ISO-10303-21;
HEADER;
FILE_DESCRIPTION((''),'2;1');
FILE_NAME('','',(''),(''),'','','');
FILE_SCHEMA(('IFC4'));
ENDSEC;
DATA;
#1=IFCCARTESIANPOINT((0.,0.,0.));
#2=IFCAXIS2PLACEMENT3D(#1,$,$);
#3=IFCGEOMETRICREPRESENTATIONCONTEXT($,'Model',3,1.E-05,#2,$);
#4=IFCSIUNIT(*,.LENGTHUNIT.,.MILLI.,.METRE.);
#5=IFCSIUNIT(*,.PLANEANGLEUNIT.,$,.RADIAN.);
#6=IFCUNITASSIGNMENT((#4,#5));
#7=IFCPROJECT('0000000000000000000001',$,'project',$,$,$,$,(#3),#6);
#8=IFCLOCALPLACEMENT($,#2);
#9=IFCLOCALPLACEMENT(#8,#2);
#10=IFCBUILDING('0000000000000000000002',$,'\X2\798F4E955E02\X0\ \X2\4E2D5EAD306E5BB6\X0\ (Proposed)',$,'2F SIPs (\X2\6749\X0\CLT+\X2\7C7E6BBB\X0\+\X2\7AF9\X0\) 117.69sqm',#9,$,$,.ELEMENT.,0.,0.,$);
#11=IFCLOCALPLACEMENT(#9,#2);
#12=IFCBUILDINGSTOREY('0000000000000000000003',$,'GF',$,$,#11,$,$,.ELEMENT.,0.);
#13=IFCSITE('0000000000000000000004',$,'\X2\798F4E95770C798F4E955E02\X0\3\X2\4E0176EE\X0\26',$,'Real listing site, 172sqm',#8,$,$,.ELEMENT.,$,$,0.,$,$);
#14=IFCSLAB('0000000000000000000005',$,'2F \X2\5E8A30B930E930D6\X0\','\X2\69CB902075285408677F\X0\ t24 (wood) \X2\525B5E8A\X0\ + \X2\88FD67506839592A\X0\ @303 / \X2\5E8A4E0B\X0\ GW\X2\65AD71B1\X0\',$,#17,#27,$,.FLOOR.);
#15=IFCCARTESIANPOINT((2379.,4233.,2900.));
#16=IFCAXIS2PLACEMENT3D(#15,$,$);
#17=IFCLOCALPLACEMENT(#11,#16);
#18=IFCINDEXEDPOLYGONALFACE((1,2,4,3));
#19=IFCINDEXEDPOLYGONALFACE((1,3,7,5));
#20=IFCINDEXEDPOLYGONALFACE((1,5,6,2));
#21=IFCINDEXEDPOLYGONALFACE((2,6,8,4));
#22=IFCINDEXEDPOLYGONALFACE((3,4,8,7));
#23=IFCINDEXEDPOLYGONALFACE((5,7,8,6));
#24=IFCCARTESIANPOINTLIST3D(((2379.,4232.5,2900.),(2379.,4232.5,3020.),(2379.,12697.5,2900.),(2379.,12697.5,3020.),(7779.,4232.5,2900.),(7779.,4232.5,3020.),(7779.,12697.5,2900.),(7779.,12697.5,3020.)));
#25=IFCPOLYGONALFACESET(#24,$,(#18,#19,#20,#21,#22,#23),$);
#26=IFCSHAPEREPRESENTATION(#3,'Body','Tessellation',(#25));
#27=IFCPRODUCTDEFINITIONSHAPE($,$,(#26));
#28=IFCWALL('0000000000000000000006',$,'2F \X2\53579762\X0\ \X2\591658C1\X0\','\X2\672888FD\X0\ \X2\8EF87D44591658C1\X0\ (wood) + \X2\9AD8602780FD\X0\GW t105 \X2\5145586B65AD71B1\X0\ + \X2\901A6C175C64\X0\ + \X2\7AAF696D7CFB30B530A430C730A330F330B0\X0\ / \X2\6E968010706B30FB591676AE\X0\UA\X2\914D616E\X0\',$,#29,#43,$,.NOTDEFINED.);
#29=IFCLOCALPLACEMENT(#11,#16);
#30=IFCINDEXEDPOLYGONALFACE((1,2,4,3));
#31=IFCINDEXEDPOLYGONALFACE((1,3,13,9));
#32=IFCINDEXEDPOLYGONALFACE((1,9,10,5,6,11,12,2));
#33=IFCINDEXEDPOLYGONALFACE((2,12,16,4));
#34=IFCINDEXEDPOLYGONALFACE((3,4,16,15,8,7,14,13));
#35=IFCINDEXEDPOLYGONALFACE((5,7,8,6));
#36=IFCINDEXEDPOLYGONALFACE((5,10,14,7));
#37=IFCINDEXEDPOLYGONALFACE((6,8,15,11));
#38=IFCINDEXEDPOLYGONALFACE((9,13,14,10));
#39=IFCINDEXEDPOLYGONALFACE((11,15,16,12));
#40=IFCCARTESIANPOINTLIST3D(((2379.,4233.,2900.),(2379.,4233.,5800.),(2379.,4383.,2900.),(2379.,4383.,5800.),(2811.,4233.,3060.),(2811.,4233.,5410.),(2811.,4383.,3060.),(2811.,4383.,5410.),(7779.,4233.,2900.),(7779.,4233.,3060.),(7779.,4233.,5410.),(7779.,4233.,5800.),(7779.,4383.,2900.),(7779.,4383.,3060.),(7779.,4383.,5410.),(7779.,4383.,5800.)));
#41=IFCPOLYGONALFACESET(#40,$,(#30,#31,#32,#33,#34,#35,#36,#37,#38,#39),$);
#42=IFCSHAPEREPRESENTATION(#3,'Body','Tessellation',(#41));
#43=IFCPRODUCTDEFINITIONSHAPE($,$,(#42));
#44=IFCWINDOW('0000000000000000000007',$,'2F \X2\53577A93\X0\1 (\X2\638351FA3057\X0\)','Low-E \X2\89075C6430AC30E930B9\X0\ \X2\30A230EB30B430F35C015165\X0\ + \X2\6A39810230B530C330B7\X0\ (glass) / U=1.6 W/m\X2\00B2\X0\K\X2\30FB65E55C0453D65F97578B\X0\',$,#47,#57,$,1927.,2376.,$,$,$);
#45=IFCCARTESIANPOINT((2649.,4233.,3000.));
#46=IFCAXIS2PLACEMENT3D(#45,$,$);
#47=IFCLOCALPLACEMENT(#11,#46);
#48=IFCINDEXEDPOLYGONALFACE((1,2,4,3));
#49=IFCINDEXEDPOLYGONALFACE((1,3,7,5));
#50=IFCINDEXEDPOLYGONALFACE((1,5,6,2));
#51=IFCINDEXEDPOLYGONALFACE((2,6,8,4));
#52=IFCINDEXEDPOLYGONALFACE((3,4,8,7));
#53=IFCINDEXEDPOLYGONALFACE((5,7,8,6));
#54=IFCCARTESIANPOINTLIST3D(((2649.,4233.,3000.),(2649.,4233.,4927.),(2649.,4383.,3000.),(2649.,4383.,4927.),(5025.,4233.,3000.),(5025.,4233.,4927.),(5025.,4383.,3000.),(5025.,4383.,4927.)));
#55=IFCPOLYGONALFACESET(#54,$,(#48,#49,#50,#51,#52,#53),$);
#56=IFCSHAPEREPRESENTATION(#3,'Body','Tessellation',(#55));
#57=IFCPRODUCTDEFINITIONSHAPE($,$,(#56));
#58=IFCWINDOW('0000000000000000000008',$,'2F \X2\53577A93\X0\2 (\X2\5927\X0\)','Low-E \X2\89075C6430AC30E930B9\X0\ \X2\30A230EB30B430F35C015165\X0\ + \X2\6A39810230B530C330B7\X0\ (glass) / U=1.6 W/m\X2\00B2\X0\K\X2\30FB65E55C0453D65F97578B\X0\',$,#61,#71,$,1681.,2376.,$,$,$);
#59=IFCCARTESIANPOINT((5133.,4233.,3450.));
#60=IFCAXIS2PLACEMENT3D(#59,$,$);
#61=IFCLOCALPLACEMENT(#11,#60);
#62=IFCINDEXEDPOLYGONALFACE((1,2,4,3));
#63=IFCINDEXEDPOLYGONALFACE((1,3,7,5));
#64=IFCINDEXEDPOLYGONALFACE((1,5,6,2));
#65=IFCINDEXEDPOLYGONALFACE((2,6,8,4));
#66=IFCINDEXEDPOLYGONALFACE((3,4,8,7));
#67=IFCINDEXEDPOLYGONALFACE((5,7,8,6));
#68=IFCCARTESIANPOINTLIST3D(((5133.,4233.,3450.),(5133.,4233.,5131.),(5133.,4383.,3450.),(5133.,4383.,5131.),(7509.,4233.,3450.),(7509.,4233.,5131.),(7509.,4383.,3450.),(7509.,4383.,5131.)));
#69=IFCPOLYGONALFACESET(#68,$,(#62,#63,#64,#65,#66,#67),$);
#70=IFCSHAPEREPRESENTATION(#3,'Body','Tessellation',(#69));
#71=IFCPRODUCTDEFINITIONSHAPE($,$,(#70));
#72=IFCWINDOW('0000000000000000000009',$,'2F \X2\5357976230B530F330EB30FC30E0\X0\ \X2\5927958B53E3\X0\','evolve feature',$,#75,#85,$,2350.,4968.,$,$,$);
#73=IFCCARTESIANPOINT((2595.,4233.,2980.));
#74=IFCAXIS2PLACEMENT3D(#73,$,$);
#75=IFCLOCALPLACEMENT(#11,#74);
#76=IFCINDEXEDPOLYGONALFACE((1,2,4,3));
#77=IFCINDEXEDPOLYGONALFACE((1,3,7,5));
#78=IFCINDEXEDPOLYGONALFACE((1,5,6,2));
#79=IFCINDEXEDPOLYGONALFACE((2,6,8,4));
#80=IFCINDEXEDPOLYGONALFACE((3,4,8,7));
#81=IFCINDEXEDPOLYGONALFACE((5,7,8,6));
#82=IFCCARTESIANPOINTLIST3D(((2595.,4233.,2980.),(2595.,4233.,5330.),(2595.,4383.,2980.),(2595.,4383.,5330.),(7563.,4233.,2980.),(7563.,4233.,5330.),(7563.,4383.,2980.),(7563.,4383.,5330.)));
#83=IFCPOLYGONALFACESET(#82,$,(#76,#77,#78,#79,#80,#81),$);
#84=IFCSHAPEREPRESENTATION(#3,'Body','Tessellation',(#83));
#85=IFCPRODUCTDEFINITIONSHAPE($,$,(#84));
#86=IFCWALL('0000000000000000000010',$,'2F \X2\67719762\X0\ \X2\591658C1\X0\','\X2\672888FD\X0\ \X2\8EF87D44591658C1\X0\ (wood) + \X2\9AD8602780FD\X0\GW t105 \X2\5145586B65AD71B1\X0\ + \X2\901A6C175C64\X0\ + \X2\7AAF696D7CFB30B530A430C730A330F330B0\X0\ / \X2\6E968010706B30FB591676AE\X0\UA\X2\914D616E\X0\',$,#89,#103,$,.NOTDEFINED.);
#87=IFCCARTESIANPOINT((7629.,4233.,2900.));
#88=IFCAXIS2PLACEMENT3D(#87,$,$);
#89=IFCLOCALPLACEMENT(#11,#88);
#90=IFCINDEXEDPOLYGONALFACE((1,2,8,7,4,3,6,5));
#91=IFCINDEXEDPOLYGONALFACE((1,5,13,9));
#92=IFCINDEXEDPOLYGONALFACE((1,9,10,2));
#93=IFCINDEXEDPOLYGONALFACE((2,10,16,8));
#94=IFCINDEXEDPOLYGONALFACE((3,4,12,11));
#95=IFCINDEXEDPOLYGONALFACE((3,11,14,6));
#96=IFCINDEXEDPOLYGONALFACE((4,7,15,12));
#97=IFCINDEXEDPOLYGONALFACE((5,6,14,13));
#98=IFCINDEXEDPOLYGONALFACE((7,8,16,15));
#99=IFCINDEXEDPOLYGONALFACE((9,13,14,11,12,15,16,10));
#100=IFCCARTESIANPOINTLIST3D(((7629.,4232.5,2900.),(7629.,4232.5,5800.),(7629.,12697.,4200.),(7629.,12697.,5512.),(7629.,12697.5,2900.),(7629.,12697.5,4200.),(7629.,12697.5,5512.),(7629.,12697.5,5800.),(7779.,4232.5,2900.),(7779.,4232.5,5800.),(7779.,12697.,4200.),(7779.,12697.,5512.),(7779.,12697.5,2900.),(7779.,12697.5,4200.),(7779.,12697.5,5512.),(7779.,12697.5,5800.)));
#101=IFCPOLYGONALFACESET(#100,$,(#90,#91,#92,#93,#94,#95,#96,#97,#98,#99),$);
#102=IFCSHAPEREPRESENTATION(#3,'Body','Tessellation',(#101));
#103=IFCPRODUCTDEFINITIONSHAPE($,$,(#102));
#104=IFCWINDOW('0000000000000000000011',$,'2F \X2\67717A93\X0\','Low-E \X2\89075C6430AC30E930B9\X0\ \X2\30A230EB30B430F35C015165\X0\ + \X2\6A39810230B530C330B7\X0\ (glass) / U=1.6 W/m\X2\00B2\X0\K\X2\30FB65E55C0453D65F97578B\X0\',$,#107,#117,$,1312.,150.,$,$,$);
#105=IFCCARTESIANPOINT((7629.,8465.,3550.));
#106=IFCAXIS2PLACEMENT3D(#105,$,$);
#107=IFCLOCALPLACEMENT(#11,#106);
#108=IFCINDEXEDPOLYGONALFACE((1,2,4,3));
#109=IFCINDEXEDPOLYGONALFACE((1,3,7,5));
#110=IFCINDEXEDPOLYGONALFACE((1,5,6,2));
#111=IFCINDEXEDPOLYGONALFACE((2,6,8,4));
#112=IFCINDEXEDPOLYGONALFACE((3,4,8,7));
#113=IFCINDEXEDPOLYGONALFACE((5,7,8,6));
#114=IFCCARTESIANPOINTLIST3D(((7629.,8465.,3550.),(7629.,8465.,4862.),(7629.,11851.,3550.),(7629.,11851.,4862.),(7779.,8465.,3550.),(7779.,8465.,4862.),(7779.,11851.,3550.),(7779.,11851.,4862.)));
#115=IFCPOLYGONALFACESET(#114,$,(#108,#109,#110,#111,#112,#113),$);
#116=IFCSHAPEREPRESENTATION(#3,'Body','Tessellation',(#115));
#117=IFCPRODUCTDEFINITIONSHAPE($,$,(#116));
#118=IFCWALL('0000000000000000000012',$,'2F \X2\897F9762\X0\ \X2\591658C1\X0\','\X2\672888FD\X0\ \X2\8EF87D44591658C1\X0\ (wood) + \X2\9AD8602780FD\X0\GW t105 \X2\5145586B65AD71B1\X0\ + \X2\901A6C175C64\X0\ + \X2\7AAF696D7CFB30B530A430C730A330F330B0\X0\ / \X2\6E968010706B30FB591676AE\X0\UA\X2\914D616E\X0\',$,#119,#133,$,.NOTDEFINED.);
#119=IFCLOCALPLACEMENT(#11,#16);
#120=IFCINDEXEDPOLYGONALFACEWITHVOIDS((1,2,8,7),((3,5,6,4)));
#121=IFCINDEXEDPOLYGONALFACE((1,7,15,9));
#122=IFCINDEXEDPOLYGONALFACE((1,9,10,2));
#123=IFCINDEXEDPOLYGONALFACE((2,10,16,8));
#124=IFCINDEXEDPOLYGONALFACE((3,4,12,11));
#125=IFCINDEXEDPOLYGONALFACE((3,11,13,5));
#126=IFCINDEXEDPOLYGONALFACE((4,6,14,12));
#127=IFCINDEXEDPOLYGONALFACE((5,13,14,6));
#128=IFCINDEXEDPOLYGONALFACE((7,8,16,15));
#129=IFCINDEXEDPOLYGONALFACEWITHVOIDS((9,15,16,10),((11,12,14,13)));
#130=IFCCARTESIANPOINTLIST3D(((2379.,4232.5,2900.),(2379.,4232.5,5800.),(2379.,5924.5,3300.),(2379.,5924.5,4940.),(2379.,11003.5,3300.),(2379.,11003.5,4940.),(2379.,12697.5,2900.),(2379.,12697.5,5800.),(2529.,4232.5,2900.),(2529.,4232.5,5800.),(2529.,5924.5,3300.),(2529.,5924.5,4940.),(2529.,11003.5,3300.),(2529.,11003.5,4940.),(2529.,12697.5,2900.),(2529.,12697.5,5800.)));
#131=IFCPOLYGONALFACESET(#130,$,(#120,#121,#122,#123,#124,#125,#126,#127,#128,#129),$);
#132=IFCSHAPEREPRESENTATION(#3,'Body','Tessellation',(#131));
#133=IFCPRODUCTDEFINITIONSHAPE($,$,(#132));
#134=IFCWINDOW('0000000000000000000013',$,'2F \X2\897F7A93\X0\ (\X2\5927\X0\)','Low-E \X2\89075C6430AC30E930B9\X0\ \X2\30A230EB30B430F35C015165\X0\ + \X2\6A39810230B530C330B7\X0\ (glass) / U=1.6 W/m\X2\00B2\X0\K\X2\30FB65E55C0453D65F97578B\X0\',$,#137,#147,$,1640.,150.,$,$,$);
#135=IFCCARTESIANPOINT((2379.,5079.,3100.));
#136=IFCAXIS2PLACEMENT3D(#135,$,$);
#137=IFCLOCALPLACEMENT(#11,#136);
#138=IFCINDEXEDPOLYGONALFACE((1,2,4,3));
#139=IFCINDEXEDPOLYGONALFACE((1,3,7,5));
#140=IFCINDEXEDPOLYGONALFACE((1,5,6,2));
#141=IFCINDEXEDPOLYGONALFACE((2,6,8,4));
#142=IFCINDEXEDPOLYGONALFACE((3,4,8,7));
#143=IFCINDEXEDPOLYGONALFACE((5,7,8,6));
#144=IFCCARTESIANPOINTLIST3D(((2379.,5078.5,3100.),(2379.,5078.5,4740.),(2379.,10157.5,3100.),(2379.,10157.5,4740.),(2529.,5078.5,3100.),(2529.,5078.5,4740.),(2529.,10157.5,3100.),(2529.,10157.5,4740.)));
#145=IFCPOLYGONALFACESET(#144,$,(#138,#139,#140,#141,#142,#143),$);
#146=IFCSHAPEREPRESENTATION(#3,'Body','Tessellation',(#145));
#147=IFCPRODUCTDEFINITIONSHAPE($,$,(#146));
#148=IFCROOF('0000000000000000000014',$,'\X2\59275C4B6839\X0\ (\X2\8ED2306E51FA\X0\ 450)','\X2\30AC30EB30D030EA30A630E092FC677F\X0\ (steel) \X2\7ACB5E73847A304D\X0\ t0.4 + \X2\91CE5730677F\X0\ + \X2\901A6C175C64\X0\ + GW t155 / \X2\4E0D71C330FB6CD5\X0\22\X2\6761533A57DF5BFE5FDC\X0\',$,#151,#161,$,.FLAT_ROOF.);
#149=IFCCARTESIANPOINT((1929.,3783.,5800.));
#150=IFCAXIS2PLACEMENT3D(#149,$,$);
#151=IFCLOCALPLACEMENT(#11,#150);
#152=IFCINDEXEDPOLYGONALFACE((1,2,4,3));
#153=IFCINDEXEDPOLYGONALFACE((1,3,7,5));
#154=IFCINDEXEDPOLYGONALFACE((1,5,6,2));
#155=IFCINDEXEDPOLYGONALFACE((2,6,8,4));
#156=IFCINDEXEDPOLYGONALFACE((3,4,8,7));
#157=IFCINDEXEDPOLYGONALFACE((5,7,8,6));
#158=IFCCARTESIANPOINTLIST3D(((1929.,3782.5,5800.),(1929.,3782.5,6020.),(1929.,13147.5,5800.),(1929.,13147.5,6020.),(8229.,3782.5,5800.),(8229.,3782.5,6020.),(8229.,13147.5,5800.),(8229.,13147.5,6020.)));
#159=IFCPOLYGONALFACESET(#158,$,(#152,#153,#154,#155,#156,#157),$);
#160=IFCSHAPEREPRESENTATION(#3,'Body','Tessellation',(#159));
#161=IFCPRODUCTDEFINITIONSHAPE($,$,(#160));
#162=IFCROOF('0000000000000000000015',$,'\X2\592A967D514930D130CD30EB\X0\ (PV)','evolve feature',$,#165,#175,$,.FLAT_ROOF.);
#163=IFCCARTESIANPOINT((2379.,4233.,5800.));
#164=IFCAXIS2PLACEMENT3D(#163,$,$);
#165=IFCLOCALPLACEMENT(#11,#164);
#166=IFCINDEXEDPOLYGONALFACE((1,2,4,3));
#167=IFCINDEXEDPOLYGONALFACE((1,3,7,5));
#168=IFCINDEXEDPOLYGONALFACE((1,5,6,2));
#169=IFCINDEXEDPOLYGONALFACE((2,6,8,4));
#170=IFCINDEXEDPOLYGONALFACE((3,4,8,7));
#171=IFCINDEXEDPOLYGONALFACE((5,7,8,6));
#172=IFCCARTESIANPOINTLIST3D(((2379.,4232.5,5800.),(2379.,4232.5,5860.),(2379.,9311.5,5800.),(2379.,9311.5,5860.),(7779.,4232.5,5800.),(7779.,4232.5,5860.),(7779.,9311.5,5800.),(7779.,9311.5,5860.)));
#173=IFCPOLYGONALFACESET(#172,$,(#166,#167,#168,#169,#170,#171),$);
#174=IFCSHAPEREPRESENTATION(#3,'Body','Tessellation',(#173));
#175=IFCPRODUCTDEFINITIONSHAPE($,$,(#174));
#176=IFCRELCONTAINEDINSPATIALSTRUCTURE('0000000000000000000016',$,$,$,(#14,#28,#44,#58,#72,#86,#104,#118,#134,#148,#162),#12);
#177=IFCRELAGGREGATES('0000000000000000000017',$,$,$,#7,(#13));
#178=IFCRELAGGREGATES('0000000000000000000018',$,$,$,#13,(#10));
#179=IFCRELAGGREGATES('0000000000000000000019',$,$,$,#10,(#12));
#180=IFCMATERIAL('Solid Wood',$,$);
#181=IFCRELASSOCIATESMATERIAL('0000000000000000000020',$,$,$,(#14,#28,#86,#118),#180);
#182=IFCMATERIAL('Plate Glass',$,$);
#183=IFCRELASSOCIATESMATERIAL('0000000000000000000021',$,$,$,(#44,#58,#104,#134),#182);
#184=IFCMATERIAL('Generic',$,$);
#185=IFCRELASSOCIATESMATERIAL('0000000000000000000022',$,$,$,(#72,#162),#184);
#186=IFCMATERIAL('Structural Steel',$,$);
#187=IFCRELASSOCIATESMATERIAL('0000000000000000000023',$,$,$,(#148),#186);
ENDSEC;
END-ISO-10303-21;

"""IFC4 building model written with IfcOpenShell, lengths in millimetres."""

from ifc_helpers import new_model, si_unit, frame, frame_2d, origin, place, context, project, spatial, rectangle, extrude, material, element, fill, save


model = new_model("IFC4")

# Units and contexts
model_context = context("Model", 3, precision=1e-05, world=origin())
ifc_project = project(units=[si_unit("LENGTHUNIT", "METRE", prefix="MILLI"), si_unit("PLANEANGLEUNIT", "RADIAN")], contexts=[model_context])

# Site, building, storey
site_placement = place(None, origin())
site = spatial("IfcSite", under=ifc_project, at=site_placement, Name="福井県福井市3丁目26", ObjectType="Real listing site, 172sqm", CompositionType="ELEMENT", RefElevation=0.0)
building_placement = place(site_placement, origin())
building = spatial("IfcBuilding", under=site, at=building_placement, Name="福井市 中庭の家 (Proposed)", ObjectType="2F SIPs (杉CLT+籾殻+竹) 117.69sqm", CompositionType="ELEMENT", ElevationOfRefHeight=0.0, ElevationOfTerrain=0.0)
storey_placement = place(building_placement, origin())
storey = spatial("IfcBuildingStorey", under=building, at=storey_placement, Name="GF", CompositionType="ELEMENT", Elevation=0.0)

# Slab
ifc_material_1 = material(Name="Solid Wood")
slab_placement = place(storey_placement, frame((2379.0, 4233.0, 2900.0)))
element("IfcSlab", 1, at=slab_placement, inside=storey, material=ifc_material_1, Name="2F 床スラブ", Description="構造用合板 t24 (wood) 剛床 + 製材根太 @303 / 床下 GW断熱", PredefinedType="FLOOR", context=model_context, shape_type="SweptSolid", body=[
    extrude(rectangle(XDim=5400.0, YDim=8465.0, at=frame_2d((2700.0, 4232.0))), frame((2379.0, 4233.0, 2900.0)), (0.0, 0.0, 1.0), 120.0),
])

# Wall, openings, windows
wall_1_placement = place(storey_placement, frame((2379.0, 4233.0, 2900.0)))
wall_1 = element("IfcWall", 2, at=wall_1_placement, inside=storey, material=ifc_material_1, Name="2F 南面 外壁", Description="木製 軸組外壁 (wood) + 高性能GW t105 充填断熱 + 通気層 + 窯業系サイディング / 準耐火・外皮UA配慮", PredefinedType="NOTDEFINED", context=model_context, shape_type="SweptSolid", body=[
    extrude(rectangle(XDim=5400.0, YDim=150.0, at=frame_2d((2700.0, 75.0))), frame((2379.0, 4233.0, 2900.0)), (0.0, 0.0, 1.0), 2900.0),
])
opening_1_placement = place(storey_placement, frame((2649.0, 4233.0, 3000.0)))
opening_1 = element("IfcOpeningElement", 3, at=opening_1_placement, cuts=wall_1, PredefinedType="NOTDEFINED", context=model_context, shape_type="SweptSolid", body=[
    extrude(rectangle(XDim=2376.0, YDim=150.0, at=frame_2d((1188.0, 75.0))), frame((2649.0, 4233.0, 3000.0)), (0.0, 0.0, 1.0), 1927.0),
])
opening_2_placement = place(storey_placement, frame((5133.0, 4233.0, 3450.0)))
opening_2 = element("IfcOpeningElement", 4, at=opening_2_placement, cuts=wall_1, PredefinedType="NOTDEFINED", context=model_context, shape_type="SweptSolid", body=[
    extrude(rectangle(XDim=2376.0, YDim=150.0, at=frame_2d((1188.0, 75.0))), frame((5133.0, 4233.0, 3450.0)), (0.0, 0.0, 1.0), 1681.0),
])
opening_3_placement = place(storey_placement, frame((2595.0, 4233.0, 2980.0)))
opening_3 = element("IfcOpeningElement", 5, at=opening_3_placement, cuts=wall_1, PredefinedType="NOTDEFINED", context=model_context, shape_type="SweptSolid", body=[
    extrude(rectangle(XDim=4968.0, YDim=150.0, at=frame_2d((2484.0, 75.0))), frame((2595.0, 4233.0, 2980.0)), (0.0, 0.0, 1.0), 2350.0),
])
ifc_material_2 = material(Name="Plate Glass")
window_1_placement = place(storey_placement, frame((2649.0, 4233.0, 3000.0)))
window_1 = element("IfcWindow", 6, at=window_1_placement, inside=storey, material=ifc_material_2, Name="2F 南窓1 (掃出し)", Description="Low-E 複層ガラス アルゴン封入 + 樹脂サッシ (glass) / U=1.6 W/m²K・日射取得型", OverallHeight=1927.0, OverallWidth=2376.0, context=model_context, shape_type="SweptSolid", body=[
    extrude(rectangle(XDim=2376.0, YDim=150.0, at=frame_2d((1188.0, 75.0))), frame((2649.0, 4233.0, 3000.0)), (0.0, 0.0, 1.0), 1927.0),
])
fill(opening_1, window_1)
window_2_placement = place(storey_placement, frame((5133.0, 4233.0, 3450.0)))
window_2 = element("IfcWindow", 7, at=window_2_placement, inside=storey, material=ifc_material_2, Name="2F 南窓2 (大)", Description="Low-E 複層ガラス アルゴン封入 + 樹脂サッシ (glass) / U=1.6 W/m²K・日射取得型", OverallHeight=1681.0, OverallWidth=2376.0, context=model_context, shape_type="SweptSolid", body=[
    extrude(rectangle(XDim=2376.0, YDim=150.0, at=frame_2d((1188.0, 75.0))), frame((5133.0, 4233.0, 3450.0)), (0.0, 0.0, 1.0), 1681.0),
])
fill(opening_2, window_2)
ifc_material_3 = material(Name="Generic")
window_3_placement = place(storey_placement, frame((2595.0, 4233.0, 2980.0)))
window_3 = element("IfcWindow", 8, at=window_3_placement, inside=storey, material=ifc_material_3, Name="2F 南面サンルーム 大開口", Description="evolve feature", OverallHeight=2350.0, OverallWidth=4968.0, context=model_context, shape_type="SweptSolid", body=[
    extrude(rectangle(XDim=4968.0, YDim=150.0, at=frame_2d((2484.0, 75.0))), frame((2595.0, 4233.0, 2980.0)), (0.0, 0.0, 1.0), 2350.0),
])
fill(opening_3, window_3)

# Walls, openings, windows
wall_2_placement = place(storey_placement, frame((7629.0, 4233.0, 2900.0)))
wall_2 = element("IfcWall", 9, at=wall_2_placement, inside=storey, material=ifc_material_1, Name="2F 東面 外壁", Description="木製 軸組外壁 (wood) + 高性能GW t105 充填断熱 + 通気層 + 窯業系サイディング / 準耐火・外皮UA配慮", PredefinedType="NOTDEFINED", context=model_context, shape_type="SweptSolid", body=[
    extrude(rectangle(XDim=150.0, YDim=8465.0, at=frame_2d((75.0, 4232.0))), frame((7629.0, 4233.0, 2900.0)), (0.0, 0.0, 1.0), 2900.0),
])
opening_4_placement = place(storey_placement, frame((7629.0, 8465.0, 3550.0)))
opening_4 = element("IfcOpeningElement", 10, at=opening_4_placement, cuts=wall_2, PredefinedType="NOTDEFINED", context=model_context, shape_type="SweptSolid", body=[
    extrude(rectangle(XDim=150.0, YDim=3386.0, at=frame_2d((75.0, 1693.0))), frame((7629.0, 8465.0, 3550.0)), (0.0, 0.0, 1.0), 1312.0),
])
window_4_placement = place(storey_placement, frame((7629.0, 8465.0, 3550.0)))
window_4 = element("IfcWindow", 11, at=window_4_placement, inside=storey, material=ifc_material_2, Name="2F 東窓", Description="Low-E 複層ガラス アルゴン封入 + 樹脂サッシ (glass) / U=1.6 W/m²K・日射取得型", OverallHeight=1312.0, OverallWidth=150.0, context=model_context, shape_type="SweptSolid", body=[
    extrude(rectangle(XDim=150.0, YDim=3386.0, at=frame_2d((75.0, 1693.0))), frame((7629.0, 8465.0, 3550.0)), (0.0, 0.0, 1.0), 1312.0),
])
fill(opening_4, window_4)
wall_3_placement = place(storey_placement, frame((2379.0, 4233.0, 2900.0)))
wall_3 = element("IfcWall", 12, at=wall_3_placement, inside=storey, material=ifc_material_1, Name="2F 西面 外壁", Description="木製 軸組外壁 (wood) + 高性能GW t105 充填断熱 + 通気層 + 窯業系サイディング / 準耐火・外皮UA配慮", PredefinedType="NOTDEFINED", context=model_context, shape_type="SweptSolid", body=[
    extrude(rectangle(XDim=150.0, YDim=8465.0, at=frame_2d((75.0, 4232.0))), frame((2379.0, 4233.0, 2900.0)), (0.0, 0.0, 1.0), 2900.0),
])
opening_5_placement = place(storey_placement, frame((2379.0, 5079.0, 3100.0)))
opening_5 = element("IfcOpeningElement", 13, at=opening_5_placement, cuts=wall_3, PredefinedType="NOTDEFINED", context=model_context, shape_type="SweptSolid", body=[
    extrude(rectangle(XDim=150.0, YDim=5079.0, at=frame_2d((75.0, 2539.0))), frame((2379.0, 5079.0, 3100.0)), (0.0, 0.0, 1.0), 1640.0),
])
window_5_placement = place(storey_placement, frame((2379.0, 5079.0, 3100.0)))
window_5 = element("IfcWindow", 14, at=window_5_placement, inside=storey, material=ifc_material_2, Name="2F 西窓 (大)", Description="Low-E 複層ガラス アルゴン封入 + 樹脂サッシ (glass) / U=1.6 W/m²K・日射取得型", OverallHeight=1640.0, OverallWidth=150.0, context=model_context, shape_type="SweptSolid", body=[
    extrude(rectangle(XDim=150.0, YDim=5079.0, at=frame_2d((75.0, 2539.0))), frame((2379.0, 5079.0, 3100.0)), (0.0, 0.0, 1.0), 1640.0),
])
fill(opening_5, window_5)

# Roofs
ifc_material_4 = material(Name="Structural Steel")
roof_1_placement = place(storey_placement, frame((1929.0, 3783.0, 5800.0)))
element("IfcRoof", 15, at=roof_1_placement, inside=storey, material=ifc_material_4, Name="大屋根 (軒の出 450)", Description="ガルバリウム鋼板 (steel) 立平葺き t0.4 + 野地板 + 通気層 + GW t155 / 不燃・法22条区域対応", PredefinedType="FLAT_ROOF", context=model_context, shape_type="SweptSolid", body=[
    extrude(rectangle(XDim=6300.0, YDim=9365.0, at=frame_2d((3150.0, 4682.0))), frame((1929.0, 3783.0, 5800.0)), (0.0, 0.0, 1.0), 220.0),
])
roof_2_placement = place(storey_placement, frame((2379.0, 4233.0, 5800.0)))
element("IfcRoof", 16, at=roof_2_placement, inside=storey, material=ifc_material_3, Name="太陽光パネル (PV)", Description="evolve feature", PredefinedType="FLAT_ROOF", context=model_context, shape_type="SweptSolid", body=[
    extrude(rectangle(XDim=5400.0, YDim=5079.0, at=frame_2d((2700.0, 2539.0))), frame((2379.0, 4233.0, 5800.0)), (0.0, 0.0, 1.0), 60.0),
])

save(model, "model.ifc")
